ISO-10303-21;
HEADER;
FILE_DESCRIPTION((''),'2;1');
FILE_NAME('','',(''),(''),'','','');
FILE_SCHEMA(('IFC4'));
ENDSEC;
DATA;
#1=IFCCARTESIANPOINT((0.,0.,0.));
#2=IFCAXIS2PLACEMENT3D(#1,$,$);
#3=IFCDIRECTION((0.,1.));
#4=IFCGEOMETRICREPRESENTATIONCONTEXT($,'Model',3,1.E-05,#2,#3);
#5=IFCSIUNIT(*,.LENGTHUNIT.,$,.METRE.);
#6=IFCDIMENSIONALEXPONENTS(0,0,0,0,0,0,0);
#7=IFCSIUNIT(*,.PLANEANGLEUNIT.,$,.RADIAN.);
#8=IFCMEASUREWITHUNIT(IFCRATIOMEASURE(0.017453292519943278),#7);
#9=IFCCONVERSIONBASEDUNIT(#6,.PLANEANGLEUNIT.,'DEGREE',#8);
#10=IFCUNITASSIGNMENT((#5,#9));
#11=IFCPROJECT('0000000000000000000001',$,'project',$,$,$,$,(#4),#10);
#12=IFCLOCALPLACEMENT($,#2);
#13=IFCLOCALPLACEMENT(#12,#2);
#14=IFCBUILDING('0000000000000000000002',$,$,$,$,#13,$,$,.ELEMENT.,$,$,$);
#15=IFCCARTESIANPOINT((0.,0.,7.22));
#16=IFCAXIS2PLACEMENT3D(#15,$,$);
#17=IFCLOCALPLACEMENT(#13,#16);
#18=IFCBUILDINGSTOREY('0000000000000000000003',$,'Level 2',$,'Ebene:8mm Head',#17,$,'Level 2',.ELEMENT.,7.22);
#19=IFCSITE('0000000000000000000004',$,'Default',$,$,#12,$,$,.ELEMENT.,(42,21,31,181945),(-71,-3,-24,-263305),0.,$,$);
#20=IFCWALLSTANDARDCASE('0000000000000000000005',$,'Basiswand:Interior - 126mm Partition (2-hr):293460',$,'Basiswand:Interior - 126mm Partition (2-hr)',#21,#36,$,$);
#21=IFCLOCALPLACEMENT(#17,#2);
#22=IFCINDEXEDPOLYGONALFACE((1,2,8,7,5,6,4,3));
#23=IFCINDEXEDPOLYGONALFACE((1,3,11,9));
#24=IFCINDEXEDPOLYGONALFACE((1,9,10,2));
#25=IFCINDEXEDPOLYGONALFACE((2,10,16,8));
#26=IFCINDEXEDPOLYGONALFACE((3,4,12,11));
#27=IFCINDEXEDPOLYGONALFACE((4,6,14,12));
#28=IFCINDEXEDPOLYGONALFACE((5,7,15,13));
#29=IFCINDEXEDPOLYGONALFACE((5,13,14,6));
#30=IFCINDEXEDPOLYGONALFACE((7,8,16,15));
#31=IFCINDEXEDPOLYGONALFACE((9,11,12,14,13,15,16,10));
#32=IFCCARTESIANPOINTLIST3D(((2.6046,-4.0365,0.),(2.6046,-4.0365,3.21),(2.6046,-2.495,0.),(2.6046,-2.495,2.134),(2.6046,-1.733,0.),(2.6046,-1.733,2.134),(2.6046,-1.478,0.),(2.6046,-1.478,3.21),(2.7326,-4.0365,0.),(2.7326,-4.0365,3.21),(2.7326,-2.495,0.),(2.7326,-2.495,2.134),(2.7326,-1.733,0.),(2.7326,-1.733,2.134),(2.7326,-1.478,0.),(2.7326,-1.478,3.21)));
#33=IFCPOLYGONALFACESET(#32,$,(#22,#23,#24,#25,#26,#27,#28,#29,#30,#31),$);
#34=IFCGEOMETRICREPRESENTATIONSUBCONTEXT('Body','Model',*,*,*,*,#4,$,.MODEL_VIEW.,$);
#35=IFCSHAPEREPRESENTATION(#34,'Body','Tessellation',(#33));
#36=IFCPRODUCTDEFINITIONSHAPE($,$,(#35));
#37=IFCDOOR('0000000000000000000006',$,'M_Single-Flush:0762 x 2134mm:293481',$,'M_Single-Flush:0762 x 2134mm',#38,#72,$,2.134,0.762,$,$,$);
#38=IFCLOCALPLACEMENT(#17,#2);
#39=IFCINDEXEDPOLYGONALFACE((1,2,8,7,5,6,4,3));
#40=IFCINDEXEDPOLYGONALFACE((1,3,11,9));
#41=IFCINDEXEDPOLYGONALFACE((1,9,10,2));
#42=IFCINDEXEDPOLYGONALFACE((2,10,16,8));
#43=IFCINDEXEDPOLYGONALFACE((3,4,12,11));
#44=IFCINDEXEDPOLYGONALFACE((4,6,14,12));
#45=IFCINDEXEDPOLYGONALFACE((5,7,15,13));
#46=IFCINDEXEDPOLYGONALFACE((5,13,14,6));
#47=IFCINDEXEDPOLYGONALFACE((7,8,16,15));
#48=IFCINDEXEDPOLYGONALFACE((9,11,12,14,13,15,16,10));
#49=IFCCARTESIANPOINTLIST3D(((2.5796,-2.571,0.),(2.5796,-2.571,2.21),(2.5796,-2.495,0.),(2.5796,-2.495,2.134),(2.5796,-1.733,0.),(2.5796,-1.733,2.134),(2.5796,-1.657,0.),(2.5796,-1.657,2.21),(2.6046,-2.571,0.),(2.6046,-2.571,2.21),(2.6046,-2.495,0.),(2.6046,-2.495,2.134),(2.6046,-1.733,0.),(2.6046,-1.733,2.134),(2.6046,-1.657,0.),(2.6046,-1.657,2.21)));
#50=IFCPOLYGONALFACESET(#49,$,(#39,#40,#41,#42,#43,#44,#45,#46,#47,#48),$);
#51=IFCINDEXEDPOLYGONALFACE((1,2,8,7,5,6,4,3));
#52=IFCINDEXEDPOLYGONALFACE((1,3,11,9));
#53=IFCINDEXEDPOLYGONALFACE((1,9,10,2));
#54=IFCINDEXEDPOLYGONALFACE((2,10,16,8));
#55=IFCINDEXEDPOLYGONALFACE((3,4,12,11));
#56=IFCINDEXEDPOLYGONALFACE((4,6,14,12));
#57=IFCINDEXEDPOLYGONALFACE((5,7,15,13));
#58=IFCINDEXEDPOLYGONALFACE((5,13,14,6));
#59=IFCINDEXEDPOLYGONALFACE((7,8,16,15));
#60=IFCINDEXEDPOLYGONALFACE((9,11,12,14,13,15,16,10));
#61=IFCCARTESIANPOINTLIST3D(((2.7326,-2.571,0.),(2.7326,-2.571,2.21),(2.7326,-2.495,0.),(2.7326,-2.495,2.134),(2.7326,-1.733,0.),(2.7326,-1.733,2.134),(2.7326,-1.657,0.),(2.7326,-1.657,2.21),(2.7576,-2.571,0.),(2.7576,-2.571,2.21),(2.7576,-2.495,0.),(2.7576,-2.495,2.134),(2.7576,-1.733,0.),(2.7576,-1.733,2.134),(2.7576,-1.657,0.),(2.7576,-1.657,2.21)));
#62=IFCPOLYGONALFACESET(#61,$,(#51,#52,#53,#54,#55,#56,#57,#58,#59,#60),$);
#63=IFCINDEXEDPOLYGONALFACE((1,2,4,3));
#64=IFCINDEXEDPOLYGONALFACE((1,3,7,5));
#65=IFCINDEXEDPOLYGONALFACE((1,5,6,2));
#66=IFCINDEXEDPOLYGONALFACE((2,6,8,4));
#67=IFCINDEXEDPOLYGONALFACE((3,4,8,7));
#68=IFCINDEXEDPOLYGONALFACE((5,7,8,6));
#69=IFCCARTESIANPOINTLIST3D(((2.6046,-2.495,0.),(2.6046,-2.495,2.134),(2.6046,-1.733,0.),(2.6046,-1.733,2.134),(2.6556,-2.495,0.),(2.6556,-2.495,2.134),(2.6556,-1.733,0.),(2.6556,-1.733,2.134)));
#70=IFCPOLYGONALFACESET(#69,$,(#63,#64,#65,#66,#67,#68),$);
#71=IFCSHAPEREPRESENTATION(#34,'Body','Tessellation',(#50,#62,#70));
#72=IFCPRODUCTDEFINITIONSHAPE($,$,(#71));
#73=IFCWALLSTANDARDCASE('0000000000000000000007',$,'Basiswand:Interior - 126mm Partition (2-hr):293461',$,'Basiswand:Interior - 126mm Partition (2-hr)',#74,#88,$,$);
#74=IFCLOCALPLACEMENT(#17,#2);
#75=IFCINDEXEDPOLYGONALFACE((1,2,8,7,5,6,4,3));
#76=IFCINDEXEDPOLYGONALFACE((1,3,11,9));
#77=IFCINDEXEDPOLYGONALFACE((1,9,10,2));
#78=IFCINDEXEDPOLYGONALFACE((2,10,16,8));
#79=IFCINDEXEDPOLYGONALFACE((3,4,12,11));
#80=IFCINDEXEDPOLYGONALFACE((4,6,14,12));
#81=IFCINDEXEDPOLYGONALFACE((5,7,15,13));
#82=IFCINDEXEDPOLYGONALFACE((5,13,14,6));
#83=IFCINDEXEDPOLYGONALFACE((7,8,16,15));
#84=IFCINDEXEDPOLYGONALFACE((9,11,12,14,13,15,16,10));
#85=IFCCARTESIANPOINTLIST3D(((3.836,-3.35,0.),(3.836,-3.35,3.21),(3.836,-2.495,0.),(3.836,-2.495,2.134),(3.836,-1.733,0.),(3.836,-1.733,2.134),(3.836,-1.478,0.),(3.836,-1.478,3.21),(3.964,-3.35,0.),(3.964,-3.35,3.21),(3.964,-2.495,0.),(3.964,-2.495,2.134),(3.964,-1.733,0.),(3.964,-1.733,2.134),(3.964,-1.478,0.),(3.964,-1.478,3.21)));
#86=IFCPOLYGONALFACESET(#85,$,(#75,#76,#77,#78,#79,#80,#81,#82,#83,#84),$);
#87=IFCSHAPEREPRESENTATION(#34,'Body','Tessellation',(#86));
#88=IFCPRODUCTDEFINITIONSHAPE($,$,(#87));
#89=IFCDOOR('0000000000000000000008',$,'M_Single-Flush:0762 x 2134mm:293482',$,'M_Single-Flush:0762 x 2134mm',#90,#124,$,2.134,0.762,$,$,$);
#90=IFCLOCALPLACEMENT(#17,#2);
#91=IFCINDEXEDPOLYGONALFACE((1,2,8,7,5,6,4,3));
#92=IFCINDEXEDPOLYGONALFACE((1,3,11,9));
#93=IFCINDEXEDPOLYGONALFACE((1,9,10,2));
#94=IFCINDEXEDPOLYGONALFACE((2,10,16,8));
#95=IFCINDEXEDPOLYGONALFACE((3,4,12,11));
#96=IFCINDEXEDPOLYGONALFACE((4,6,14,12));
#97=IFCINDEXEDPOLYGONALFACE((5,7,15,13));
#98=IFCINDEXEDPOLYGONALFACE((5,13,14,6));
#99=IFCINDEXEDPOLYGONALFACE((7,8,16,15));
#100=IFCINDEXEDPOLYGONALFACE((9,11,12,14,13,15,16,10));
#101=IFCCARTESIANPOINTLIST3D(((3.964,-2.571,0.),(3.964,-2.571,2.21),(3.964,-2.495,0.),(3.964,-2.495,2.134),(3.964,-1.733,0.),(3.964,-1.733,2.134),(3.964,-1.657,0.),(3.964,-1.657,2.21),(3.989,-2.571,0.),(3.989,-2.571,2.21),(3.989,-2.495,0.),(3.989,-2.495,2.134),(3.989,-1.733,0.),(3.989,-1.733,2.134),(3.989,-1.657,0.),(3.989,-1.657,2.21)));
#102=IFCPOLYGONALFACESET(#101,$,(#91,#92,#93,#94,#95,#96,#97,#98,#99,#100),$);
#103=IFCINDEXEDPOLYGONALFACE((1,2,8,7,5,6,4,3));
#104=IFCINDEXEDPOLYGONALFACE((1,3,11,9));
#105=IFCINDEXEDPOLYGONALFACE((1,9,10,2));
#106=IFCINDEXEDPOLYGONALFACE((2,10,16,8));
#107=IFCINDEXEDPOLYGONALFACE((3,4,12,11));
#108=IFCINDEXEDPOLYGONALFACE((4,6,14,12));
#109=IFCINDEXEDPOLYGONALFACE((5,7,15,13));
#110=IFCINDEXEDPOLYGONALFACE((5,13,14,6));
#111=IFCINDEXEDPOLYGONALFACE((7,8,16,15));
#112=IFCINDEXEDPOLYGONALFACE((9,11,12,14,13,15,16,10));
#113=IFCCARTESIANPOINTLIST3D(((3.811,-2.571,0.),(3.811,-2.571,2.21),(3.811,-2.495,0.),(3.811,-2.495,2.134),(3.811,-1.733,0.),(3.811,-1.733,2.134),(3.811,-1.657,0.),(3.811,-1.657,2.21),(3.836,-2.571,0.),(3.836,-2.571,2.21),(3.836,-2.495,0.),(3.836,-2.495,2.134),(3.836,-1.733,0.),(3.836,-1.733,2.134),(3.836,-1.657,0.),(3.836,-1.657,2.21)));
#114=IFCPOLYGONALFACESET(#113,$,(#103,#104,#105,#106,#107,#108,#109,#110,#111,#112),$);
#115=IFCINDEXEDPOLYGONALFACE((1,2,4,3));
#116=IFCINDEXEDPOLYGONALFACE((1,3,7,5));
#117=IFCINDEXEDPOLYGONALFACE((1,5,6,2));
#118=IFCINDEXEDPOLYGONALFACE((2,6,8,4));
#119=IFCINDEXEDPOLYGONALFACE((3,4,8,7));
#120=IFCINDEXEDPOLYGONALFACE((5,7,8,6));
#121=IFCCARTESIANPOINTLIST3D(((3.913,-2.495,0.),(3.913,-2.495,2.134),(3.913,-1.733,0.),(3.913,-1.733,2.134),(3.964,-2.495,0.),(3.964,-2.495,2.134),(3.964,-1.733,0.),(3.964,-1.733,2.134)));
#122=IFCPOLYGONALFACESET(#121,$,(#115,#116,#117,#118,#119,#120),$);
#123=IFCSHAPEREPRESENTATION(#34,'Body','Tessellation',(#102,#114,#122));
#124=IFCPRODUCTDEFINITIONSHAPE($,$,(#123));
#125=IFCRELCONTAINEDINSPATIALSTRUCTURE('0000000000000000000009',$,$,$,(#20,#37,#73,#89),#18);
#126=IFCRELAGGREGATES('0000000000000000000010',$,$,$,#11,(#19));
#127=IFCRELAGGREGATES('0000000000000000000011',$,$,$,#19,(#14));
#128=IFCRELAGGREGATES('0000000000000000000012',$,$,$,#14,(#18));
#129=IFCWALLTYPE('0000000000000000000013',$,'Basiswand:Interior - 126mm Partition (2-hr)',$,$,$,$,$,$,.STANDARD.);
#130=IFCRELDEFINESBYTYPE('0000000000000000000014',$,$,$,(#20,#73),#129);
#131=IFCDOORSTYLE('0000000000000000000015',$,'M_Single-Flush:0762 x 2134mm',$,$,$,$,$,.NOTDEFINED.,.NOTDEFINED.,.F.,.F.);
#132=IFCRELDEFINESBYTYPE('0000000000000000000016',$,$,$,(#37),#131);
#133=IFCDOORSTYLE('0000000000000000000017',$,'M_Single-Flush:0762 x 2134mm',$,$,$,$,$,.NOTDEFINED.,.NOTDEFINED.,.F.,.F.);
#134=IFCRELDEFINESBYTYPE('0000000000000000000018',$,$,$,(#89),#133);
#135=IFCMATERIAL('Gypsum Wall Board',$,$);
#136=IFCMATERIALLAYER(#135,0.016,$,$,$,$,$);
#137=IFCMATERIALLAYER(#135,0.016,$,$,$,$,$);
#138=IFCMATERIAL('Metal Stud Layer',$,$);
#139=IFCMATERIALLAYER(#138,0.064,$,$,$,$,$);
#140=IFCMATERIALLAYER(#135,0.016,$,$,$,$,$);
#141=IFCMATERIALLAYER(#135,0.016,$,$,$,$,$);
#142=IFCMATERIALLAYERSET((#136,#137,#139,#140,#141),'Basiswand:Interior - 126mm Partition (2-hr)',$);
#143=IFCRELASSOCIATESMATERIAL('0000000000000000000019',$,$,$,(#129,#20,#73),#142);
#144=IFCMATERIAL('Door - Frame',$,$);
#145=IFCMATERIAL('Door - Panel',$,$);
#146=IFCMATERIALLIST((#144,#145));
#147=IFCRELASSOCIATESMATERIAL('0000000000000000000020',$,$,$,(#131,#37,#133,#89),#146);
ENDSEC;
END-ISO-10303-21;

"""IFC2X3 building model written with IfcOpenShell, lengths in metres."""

from ifc_helpers import new_model, entity, si_unit, converted_unit, direction, frame, frame_2d, origin, place, context, subcontext, project, spatial, polyline, rectangle, outline, extrude, clip, bounded_halfspace, source, transform, mapped, material, material_list, layer, layer_set, layer_usage, type_object, type_shapes, element, fill, save


model = new_model("IFC2X3")

# Units and contexts
model_context = context("Model", 3, precision=1e-05, world=origin(), true_north=direction((0.0, 1.0)))
body_context = subcontext(model_context, "Body", "Model", "MODEL_VIEW")
ifc_project = project(units=[si_unit("LENGTHUNIT", "METRE"), converted_unit("PLANEANGLEUNIT", "DEGREE", entity("IfcRatioMeasure", 0.017453292519943278), si_unit("PLANEANGLEUNIT", "RADIAN"), dimensions=[0, 0, 0, 0, 0, 0, 0])], contexts=[model_context])

# Site, building, storey
site_placement = place(None, origin())
site = spatial("IfcSite", under=ifc_project, at=site_placement, Name="Default", CompositionType="ELEMENT", RefLatitude=(42, 21, 31, 181945), RefLongitude=(-71, -3, -24, -263305), RefElevation=0.0)
building_placement = place(site_placement, origin())
building = spatial("IfcBuilding", under=site, at=building_placement, CompositionType="ELEMENT")
storey_placement = place(building_placement, frame((0.0, 0.0, 7.22)))
storey = spatial("IfcBuildingStorey", under=building, at=storey_placement, Name="Level 2", ObjectType="Ebene:8mm Head", LongName="Level 2", CompositionType="ELEMENT", Elevation=7.22)

# Shared definitions
ifc_material_1 = material(Name="Door - Frame")
ifc_material_2 = material(Name="Door - Panel")
ifc_material_list = material_list([ifc_material_1, ifc_material_2])

# Shared definitions
ifc_material_3 = material(Name="Gypsum Wall Board")
ifc_layer_1 = layer(ifc_material_3, 0.016)
ifc_layer_2 = layer(ifc_material_3, 0.016)
ifc_material_4 = material(Name="Metal Stud Layer")
ifc_layer_3 = layer(ifc_material_4, 0.064)
ifc_layer_4 = layer(ifc_material_3, 0.016)
ifc_layer_5 = layer(ifc_material_3, 0.016)
ifc_layer_set_1 = layer_set([ifc_layer_1, ifc_layer_2, ifc_layer_3, ifc_layer_4, ifc_layer_5], Name="Basiswand:Interior - 126mm Partition (2-hr)")
ifc_layer_usage_1 = layer_usage(ifc_layer_set_1, "AXIS2", "NEGATIVE", 0.064)
wall_type_1 = type_object("IfcWallType", Name="Basiswand:Interior - 126mm Partition (2-hr)", PredefinedType="STANDARD", material=ifc_layer_set_1)

# Walls, openings, doors
wall_1_placement = place(storey_placement, frame((2.6686, -4.0365, 0.0), z_axis=(0.0, 0.0, 1.0), x_axis=(0.0, 1.0, 0.0)))
wall_1 = element("IfcWallStandardCase", 1, at=wall_1_placement, inside=storey, type_object=wall_type_1, material=ifc_layer_usage_1, Name="Basiswand:Interior - 126mm Partition (2-hr):293460", ObjectType="Basiswand:Interior - 126mm Partition (2-hr)", context=body_context, shape_type="Clipping", body=[
    clip(extrude(rectangle(XDim=2.5585, YDim=0.128, at=frame_2d((1.2792, 0.0), x_axis=(-1.0, 0.0))), origin(), (0.0, 0.0, 1.0), 3.21), bounded_halfspace(frame((0.0, -0.064, 3.21), z_axis=(0.0, 0.0, -1.0), x_axis=(1.0, 0.0, 0.0)), True, frame((0.0, -0.064, 3.21)), polyline([(0.0, 0.0), (2.5585, 0.0), (2.5585, 0.128), (0.7365, 0.128), (0.6085, 0.128), (0.0, 0.128), (0.0, 0.0)]))),
])
opening_1_placement = place(wall_1_placement, frame((1.5415, -0.064, 0.0)))
opening_1 = element("IfcOpeningElement", 2, at=opening_1_placement, cuts=wall_1, ObjectType="Opening", context=body_context, shape_type="SweptSolid", body=[
    extrude(rectangle(XDim=0.762, YDim=2.134, at=frame_2d((1.067, 0.381), x_axis=(0.0, 1.0))), frame((0.0, 0.0, 0.0), z_axis=(0.0, 1.0, 0.0), x_axis=(0.0, 0.0, 1.0)), (0.0, 0.0, 1.0), 0.128),
])
door_style_1 = type_object("IfcDoorStyle", Name="M_Single-Flush:0762 x 2134mm", ConstructionType="NOTDEFINED", OperationType="NOTDEFINED", ParameterTakesPrecedence=False, Sizeable=False, material=ifc_material_list)
shared_shape_1 = source(origin(), body_context, "Body", "SweptSolid", [
    extrude(outline(polyline([(-0.457, -1.124), (0.457, -1.124), (0.457, 1.086), (0.381, 1.086), (0.381, -1.048), (-0.381, -1.048), (-0.381, 1.086), (-0.457, 1.086), (-0.457, -1.124)])), frame((0.381, 0.128, 1.086), z_axis=(0.0, 1.0, 0.0), x_axis=(1.0, 0.0, 0.0)), (0.0, 0.0, 1.0), 0.025),
    extrude(outline(polyline([(-1.124, -0.457), (1.086, -0.457), (1.086, -0.381), (-1.048, -0.381), (-1.048, 0.381), (1.086, 0.381), (1.086, 0.457), (-1.124, 0.457), (-1.124, -0.457)])), frame((0.381, -0.025, 1.086), z_axis=(0.0, 1.0, 0.0), x_axis=(0.0, 0.0, -1.0)), (0.0, 0.0, 1.0), 0.025),
    extrude(rectangle(XDim=0.051, YDim=0.762, at=frame_2d((0.0, 0.0), x_axis=(1.0, 0.0))), frame((0.381, 0.1025, 0.0), z_axis=(0.0, 0.0, 1.0), x_axis=(0.0, 1.0, 0.0)), (0.0, 0.0, 1.0), 2.134),
])
type_shapes(door_style_1, [shared_shape_1])
door_1_placement = place(opening_1_placement, origin())
door_1 = element("IfcDoor", 3, at=door_1_placement, inside=storey, type_object=door_style_1, material=ifc_material_list, Name="M_Single-Flush:0762 x 2134mm:293481", ObjectType="M_Single-Flush:0762 x 2134mm", OverallHeight=2.134, OverallWidth=0.762, context=body_context, shape_type="MappedRepresentation", body=[
    mapped(shared_shape_1, transform((0.0, 0.0, 0.0), scale=1.0)),
])
fill(opening_1, door_1)
wall_2_placement = place(storey_placement, frame((3.9, -3.35, 0.0), z_axis=(0.0, 0.0, 1.0), x_axis=(0.0, 1.0, 0.0)))
wall_2 = element("IfcWallStandardCase", 4, at=wall_2_placement, inside=storey, type_object=wall_type_1, material=ifc_layer_usage_1, Name="Basiswand:Interior - 126mm Partition (2-hr):293461", ObjectType="Basiswand:Interior - 126mm Partition (2-hr)", context=body_context, shape_type="Clipping", body=[
    clip(extrude(rectangle(XDim=1.872, YDim=0.128, at=frame_2d((0.936, 0.0), x_axis=(1.0, 0.0))), origin(), (0.0, 0.0, 1.0), 3.21), bounded_halfspace(frame((0.0, -0.064, 3.21), z_axis=(0.0, 0.0, -1.0), x_axis=(1.0, 0.0, 0.0)), True, frame((0.0, -0.064, 3.21)), polyline([(0.0, 0.0), (1.872, 0.0), (1.872, 0.128), (0.0, 0.128), (0.0, 0.0)]))),
])
opening_2_placement = place(wall_2_placement, frame((1.617, 0.064, 0.0)))
opening_2 = element("IfcOpeningElement", 5, at=opening_2_placement, cuts=wall_2, ObjectType="Opening", context=body_context, shape_type="SweptSolid", body=[
    extrude(rectangle(XDim=0.762, YDim=2.134, at=frame_2d((1.067, 0.381), x_axis=(0.0, -1.0))), frame((0.0, 0.0, 0.0), z_axis=(0.0, -1.0, 0.0), x_axis=(0.0, 0.0, 1.0)), (0.0, 0.0, 1.0), 0.128),
])
door_style_2 = type_object("IfcDoorStyle", Name="M_Single-Flush:0762 x 2134mm", ConstructionType="NOTDEFINED", OperationType="NOTDEFINED", ParameterTakesPrecedence=False, Sizeable=False, material=ifc_material_list)
shared_shape_2 = source(origin(), body_context, "Body", "SweptSolid", [
    extrude(outline(polyline([(-0.457, -1.124), (0.457, -1.124), (0.457, 1.086), (0.381, 1.086), (0.381, -1.048), (-0.381, -1.048), (-0.381, 1.086), (-0.457, 1.086), (-0.457, -1.124)])), frame((0.381, 0.153, 1.086), z_axis=(0.0, -1.0, 0.0), x_axis=(-1.0, 0.0, 0.0)), (0.0, 0.0, 1.0), 0.025),
    extrude(outline(polyline([(-1.124, -0.457), (1.086, -0.457), (1.086, -0.381), (-1.048, -0.381), (-1.048, 0.381), (1.086, 0.381), (1.086, 0.457), (-1.124, 0.457), (-1.124, -0.457)])), frame((0.381, 0.0, 1.086), z_axis=(0.0, -1.0, 0.0), x_axis=(0.0, 0.0, -1.0)), (0.0, 0.0, 1.0), 0.025),
    extrude(rectangle(XDim=0.762, YDim=0.051, at=frame_2d((0.0, 0.0), x_axis=(1.0, 0.0))), frame((0.381, 0.1025, 0.0)), (0.0, 0.0, 1.0), 2.134),
])
type_shapes(door_style_2, [shared_shape_2])
door_2_placement = place(opening_2_placement, frame((0.0, 0.0, 0.0), z_axis=(0.0, 0.0, 1.0), x_axis=(-1.0, 0.0, 0.0)))
door_2 = element("IfcDoor", 6, at=door_2_placement, inside=storey, type_object=door_style_2, material=ifc_material_list, Name="M_Single-Flush:0762 x 2134mm:293482", ObjectType="M_Single-Flush:0762 x 2134mm", OverallHeight=2.134, OverallWidth=0.762, context=body_context, shape_type="MappedRepresentation", body=[
    mapped(shared_shape_2, transform((0.0, 0.0, 0.0), scale=1.0)),
])
fill(opening_2, door_2)

save(model, "model.ifc")
